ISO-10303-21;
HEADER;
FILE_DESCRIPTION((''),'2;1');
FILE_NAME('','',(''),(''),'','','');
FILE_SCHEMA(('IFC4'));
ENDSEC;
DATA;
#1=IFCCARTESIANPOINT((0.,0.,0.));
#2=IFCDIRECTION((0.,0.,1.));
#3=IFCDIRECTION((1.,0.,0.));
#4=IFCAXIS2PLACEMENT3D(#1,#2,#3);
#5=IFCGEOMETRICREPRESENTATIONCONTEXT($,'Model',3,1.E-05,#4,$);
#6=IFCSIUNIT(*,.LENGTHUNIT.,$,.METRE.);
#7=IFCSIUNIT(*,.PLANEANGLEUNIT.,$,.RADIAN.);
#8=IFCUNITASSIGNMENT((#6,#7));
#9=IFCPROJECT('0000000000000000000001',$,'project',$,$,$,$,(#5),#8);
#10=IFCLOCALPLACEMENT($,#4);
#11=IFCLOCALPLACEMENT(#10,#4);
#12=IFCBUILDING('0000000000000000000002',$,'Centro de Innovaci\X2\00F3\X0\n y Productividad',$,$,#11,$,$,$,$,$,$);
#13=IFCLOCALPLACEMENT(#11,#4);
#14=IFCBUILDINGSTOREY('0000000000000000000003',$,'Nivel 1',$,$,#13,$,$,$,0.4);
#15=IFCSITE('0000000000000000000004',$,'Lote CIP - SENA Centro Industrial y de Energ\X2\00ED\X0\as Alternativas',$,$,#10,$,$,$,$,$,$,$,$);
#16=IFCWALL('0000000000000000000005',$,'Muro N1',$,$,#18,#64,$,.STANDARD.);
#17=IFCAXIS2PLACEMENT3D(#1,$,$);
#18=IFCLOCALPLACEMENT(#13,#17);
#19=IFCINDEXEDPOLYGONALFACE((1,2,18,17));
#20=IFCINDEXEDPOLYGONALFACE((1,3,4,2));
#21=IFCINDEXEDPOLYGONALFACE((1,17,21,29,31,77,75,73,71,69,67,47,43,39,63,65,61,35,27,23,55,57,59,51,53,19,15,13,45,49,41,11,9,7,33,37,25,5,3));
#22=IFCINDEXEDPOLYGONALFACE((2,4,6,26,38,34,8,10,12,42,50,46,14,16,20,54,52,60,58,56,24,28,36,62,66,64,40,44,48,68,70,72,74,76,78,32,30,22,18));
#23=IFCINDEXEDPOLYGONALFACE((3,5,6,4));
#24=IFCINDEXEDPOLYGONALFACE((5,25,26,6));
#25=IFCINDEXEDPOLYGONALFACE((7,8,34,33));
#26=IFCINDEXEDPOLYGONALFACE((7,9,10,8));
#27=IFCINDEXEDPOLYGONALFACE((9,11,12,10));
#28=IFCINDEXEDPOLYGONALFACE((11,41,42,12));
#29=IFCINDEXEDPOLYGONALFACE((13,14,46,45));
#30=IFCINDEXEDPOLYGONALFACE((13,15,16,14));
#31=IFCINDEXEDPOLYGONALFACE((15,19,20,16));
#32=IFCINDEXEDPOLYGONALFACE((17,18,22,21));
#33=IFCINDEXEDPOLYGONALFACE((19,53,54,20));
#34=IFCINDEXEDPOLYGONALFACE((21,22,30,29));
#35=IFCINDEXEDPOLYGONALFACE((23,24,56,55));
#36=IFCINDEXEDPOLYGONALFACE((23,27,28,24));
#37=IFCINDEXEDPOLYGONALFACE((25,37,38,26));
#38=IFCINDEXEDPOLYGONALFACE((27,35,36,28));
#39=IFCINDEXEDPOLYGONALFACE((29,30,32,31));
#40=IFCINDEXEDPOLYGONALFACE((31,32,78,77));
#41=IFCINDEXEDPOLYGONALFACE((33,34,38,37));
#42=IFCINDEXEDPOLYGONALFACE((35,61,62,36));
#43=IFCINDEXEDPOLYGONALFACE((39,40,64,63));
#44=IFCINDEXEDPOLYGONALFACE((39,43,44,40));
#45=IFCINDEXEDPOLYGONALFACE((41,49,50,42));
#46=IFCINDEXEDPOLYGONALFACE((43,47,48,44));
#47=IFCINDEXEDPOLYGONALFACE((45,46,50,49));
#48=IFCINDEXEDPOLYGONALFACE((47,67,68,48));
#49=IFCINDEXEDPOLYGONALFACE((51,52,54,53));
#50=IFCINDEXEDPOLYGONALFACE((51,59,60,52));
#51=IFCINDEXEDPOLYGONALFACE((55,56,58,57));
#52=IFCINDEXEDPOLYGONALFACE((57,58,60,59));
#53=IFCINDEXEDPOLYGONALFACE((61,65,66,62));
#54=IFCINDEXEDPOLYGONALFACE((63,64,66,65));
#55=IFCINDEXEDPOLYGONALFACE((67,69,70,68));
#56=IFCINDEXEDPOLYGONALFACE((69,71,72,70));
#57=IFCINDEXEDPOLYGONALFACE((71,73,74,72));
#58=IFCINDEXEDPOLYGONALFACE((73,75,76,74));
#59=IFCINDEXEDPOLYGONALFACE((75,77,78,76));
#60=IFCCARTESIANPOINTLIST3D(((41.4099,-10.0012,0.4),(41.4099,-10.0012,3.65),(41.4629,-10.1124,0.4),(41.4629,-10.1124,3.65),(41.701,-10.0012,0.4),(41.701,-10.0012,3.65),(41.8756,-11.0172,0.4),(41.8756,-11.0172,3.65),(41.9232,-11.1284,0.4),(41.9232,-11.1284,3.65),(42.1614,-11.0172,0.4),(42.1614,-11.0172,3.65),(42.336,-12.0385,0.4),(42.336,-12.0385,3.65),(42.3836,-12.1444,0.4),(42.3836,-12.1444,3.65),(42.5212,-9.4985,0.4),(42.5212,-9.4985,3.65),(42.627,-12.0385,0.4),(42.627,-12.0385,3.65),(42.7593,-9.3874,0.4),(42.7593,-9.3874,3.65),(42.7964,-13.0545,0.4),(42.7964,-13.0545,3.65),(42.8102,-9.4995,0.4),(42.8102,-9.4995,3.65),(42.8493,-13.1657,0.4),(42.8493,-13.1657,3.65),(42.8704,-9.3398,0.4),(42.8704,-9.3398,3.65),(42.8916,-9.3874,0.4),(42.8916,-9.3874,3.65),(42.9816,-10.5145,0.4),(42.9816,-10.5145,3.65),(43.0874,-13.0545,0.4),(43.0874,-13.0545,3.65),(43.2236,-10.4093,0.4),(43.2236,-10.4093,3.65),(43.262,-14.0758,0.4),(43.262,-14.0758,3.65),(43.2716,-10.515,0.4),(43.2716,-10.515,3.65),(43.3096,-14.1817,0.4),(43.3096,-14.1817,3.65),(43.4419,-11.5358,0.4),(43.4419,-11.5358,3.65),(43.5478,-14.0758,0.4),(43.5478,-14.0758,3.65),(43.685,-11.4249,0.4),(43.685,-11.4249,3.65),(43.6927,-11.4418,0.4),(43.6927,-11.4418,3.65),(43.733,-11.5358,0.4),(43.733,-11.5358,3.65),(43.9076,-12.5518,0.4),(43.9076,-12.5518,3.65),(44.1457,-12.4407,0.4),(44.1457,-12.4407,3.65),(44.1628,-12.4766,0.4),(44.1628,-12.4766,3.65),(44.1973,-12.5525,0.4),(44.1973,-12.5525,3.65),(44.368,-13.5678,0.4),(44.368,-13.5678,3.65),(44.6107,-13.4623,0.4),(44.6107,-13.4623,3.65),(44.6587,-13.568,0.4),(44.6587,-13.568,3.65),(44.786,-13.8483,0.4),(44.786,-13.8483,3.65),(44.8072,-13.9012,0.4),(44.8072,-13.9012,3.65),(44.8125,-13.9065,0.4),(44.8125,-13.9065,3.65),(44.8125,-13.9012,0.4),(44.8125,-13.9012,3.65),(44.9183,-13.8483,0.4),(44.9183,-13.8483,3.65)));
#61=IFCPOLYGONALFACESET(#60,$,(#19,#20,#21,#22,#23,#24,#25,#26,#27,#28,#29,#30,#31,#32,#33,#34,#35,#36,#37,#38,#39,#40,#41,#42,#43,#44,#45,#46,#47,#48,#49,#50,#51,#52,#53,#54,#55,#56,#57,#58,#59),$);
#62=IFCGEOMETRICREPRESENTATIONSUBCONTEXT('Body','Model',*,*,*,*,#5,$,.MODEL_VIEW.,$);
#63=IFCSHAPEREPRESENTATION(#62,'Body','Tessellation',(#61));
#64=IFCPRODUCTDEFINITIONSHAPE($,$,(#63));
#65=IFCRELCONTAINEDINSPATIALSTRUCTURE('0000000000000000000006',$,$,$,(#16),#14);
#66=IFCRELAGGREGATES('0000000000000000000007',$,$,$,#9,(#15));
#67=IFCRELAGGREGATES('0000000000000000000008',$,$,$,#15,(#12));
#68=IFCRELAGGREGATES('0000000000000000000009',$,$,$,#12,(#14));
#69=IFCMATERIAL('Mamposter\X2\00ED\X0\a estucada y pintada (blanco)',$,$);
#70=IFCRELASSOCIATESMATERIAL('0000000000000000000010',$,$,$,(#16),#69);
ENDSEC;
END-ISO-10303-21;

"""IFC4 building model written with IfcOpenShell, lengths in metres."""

from ifc_helpers import new_model, si_unit, frame, origin_with_axes, place, context, subcontext, project, spatial, polyline, outline, extrude, material, element, save


model = new_model("IFC4")

# Units and contexts
model_context = context("Model", 3, precision=1e-05, world=origin_with_axes())
body_context = subcontext(model_context, "Body", "Model", "MODEL_VIEW")
ifc_project = project(units=[si_unit("LENGTHUNIT", "METRE"), si_unit("PLANEANGLEUNIT", "RADIAN")], contexts=[model_context])

# Site, building, storey
site_placement = place(None, origin_with_axes())
site = spatial("IfcSite", under=ifc_project, at=site_placement, Name="Lote CIP - SENA Centro Industrial y de Energías Alternativas")
building_placement = place(site_placement, origin_with_axes())
building = spatial("IfcBuilding", under=site, at=building_placement, Name="Centro de Innovación y Productividad")
storey_placement = place(building_placement, origin_with_axes())
storey = spatial("IfcBuildingStorey", under=building, at=storey_placement, Name="Nivel 1", Elevation=0.4)

# Wall
ifc_material_1 = material(Name="Mampostería estucada y pintada (blanco)")
wall_1_placement = place(storey_placement, origin_with_axes())
element("IfcWall", 1, at=wall_1_placement, inside=storey, material=ifc_material_1, Name="Muro N1", PredefinedType="STANDARD", context=body_context, shape_type="SweptSolid", body=[
    extrude(outline(polyline([(42.7964, -13.0545), (43.9076, -12.5518), (44.1457, -12.4407), (44.1628, -12.4766), (43.6927, -11.4418), (43.733, -11.5358), (42.627, -12.0385), (42.3836, -12.1444), (42.336, -12.0385), (43.4419, -11.5358), (43.685, -11.4249), (43.2716, -10.515), (42.1614, -11.0172), (41.9232, -11.1284), (41.8756, -11.0172), (42.9816, -10.5145), (43.2236, -10.4093), (42.8102, -9.4995), (41.701, -10.0012), (41.4629, -10.1124), (41.4099, -10.0012), (42.5212, -9.4985), (42.7593, -9.3874), (42.8704, -9.3398), (42.8916, -9.3874), (44.9183, -13.8483), (44.8125, -13.9012), (44.8125, -13.9065), (44.8072, -13.9012), (44.786, -13.8483), (44.6587, -13.568), (43.5478, -14.0758), (43.3096, -14.1817), (43.262, -14.0758), (44.368, -13.5678), (44.6107, -13.4623), (44.1973, -12.5525), (43.0874, -13.0545), (42.8493, -13.1657), (42.7964, -13.0545)])), frame((0.0, 0.0, 0.4)), (0.0, 0.0, 1.0), 3.25),
])

save(model, "model.ifc")
